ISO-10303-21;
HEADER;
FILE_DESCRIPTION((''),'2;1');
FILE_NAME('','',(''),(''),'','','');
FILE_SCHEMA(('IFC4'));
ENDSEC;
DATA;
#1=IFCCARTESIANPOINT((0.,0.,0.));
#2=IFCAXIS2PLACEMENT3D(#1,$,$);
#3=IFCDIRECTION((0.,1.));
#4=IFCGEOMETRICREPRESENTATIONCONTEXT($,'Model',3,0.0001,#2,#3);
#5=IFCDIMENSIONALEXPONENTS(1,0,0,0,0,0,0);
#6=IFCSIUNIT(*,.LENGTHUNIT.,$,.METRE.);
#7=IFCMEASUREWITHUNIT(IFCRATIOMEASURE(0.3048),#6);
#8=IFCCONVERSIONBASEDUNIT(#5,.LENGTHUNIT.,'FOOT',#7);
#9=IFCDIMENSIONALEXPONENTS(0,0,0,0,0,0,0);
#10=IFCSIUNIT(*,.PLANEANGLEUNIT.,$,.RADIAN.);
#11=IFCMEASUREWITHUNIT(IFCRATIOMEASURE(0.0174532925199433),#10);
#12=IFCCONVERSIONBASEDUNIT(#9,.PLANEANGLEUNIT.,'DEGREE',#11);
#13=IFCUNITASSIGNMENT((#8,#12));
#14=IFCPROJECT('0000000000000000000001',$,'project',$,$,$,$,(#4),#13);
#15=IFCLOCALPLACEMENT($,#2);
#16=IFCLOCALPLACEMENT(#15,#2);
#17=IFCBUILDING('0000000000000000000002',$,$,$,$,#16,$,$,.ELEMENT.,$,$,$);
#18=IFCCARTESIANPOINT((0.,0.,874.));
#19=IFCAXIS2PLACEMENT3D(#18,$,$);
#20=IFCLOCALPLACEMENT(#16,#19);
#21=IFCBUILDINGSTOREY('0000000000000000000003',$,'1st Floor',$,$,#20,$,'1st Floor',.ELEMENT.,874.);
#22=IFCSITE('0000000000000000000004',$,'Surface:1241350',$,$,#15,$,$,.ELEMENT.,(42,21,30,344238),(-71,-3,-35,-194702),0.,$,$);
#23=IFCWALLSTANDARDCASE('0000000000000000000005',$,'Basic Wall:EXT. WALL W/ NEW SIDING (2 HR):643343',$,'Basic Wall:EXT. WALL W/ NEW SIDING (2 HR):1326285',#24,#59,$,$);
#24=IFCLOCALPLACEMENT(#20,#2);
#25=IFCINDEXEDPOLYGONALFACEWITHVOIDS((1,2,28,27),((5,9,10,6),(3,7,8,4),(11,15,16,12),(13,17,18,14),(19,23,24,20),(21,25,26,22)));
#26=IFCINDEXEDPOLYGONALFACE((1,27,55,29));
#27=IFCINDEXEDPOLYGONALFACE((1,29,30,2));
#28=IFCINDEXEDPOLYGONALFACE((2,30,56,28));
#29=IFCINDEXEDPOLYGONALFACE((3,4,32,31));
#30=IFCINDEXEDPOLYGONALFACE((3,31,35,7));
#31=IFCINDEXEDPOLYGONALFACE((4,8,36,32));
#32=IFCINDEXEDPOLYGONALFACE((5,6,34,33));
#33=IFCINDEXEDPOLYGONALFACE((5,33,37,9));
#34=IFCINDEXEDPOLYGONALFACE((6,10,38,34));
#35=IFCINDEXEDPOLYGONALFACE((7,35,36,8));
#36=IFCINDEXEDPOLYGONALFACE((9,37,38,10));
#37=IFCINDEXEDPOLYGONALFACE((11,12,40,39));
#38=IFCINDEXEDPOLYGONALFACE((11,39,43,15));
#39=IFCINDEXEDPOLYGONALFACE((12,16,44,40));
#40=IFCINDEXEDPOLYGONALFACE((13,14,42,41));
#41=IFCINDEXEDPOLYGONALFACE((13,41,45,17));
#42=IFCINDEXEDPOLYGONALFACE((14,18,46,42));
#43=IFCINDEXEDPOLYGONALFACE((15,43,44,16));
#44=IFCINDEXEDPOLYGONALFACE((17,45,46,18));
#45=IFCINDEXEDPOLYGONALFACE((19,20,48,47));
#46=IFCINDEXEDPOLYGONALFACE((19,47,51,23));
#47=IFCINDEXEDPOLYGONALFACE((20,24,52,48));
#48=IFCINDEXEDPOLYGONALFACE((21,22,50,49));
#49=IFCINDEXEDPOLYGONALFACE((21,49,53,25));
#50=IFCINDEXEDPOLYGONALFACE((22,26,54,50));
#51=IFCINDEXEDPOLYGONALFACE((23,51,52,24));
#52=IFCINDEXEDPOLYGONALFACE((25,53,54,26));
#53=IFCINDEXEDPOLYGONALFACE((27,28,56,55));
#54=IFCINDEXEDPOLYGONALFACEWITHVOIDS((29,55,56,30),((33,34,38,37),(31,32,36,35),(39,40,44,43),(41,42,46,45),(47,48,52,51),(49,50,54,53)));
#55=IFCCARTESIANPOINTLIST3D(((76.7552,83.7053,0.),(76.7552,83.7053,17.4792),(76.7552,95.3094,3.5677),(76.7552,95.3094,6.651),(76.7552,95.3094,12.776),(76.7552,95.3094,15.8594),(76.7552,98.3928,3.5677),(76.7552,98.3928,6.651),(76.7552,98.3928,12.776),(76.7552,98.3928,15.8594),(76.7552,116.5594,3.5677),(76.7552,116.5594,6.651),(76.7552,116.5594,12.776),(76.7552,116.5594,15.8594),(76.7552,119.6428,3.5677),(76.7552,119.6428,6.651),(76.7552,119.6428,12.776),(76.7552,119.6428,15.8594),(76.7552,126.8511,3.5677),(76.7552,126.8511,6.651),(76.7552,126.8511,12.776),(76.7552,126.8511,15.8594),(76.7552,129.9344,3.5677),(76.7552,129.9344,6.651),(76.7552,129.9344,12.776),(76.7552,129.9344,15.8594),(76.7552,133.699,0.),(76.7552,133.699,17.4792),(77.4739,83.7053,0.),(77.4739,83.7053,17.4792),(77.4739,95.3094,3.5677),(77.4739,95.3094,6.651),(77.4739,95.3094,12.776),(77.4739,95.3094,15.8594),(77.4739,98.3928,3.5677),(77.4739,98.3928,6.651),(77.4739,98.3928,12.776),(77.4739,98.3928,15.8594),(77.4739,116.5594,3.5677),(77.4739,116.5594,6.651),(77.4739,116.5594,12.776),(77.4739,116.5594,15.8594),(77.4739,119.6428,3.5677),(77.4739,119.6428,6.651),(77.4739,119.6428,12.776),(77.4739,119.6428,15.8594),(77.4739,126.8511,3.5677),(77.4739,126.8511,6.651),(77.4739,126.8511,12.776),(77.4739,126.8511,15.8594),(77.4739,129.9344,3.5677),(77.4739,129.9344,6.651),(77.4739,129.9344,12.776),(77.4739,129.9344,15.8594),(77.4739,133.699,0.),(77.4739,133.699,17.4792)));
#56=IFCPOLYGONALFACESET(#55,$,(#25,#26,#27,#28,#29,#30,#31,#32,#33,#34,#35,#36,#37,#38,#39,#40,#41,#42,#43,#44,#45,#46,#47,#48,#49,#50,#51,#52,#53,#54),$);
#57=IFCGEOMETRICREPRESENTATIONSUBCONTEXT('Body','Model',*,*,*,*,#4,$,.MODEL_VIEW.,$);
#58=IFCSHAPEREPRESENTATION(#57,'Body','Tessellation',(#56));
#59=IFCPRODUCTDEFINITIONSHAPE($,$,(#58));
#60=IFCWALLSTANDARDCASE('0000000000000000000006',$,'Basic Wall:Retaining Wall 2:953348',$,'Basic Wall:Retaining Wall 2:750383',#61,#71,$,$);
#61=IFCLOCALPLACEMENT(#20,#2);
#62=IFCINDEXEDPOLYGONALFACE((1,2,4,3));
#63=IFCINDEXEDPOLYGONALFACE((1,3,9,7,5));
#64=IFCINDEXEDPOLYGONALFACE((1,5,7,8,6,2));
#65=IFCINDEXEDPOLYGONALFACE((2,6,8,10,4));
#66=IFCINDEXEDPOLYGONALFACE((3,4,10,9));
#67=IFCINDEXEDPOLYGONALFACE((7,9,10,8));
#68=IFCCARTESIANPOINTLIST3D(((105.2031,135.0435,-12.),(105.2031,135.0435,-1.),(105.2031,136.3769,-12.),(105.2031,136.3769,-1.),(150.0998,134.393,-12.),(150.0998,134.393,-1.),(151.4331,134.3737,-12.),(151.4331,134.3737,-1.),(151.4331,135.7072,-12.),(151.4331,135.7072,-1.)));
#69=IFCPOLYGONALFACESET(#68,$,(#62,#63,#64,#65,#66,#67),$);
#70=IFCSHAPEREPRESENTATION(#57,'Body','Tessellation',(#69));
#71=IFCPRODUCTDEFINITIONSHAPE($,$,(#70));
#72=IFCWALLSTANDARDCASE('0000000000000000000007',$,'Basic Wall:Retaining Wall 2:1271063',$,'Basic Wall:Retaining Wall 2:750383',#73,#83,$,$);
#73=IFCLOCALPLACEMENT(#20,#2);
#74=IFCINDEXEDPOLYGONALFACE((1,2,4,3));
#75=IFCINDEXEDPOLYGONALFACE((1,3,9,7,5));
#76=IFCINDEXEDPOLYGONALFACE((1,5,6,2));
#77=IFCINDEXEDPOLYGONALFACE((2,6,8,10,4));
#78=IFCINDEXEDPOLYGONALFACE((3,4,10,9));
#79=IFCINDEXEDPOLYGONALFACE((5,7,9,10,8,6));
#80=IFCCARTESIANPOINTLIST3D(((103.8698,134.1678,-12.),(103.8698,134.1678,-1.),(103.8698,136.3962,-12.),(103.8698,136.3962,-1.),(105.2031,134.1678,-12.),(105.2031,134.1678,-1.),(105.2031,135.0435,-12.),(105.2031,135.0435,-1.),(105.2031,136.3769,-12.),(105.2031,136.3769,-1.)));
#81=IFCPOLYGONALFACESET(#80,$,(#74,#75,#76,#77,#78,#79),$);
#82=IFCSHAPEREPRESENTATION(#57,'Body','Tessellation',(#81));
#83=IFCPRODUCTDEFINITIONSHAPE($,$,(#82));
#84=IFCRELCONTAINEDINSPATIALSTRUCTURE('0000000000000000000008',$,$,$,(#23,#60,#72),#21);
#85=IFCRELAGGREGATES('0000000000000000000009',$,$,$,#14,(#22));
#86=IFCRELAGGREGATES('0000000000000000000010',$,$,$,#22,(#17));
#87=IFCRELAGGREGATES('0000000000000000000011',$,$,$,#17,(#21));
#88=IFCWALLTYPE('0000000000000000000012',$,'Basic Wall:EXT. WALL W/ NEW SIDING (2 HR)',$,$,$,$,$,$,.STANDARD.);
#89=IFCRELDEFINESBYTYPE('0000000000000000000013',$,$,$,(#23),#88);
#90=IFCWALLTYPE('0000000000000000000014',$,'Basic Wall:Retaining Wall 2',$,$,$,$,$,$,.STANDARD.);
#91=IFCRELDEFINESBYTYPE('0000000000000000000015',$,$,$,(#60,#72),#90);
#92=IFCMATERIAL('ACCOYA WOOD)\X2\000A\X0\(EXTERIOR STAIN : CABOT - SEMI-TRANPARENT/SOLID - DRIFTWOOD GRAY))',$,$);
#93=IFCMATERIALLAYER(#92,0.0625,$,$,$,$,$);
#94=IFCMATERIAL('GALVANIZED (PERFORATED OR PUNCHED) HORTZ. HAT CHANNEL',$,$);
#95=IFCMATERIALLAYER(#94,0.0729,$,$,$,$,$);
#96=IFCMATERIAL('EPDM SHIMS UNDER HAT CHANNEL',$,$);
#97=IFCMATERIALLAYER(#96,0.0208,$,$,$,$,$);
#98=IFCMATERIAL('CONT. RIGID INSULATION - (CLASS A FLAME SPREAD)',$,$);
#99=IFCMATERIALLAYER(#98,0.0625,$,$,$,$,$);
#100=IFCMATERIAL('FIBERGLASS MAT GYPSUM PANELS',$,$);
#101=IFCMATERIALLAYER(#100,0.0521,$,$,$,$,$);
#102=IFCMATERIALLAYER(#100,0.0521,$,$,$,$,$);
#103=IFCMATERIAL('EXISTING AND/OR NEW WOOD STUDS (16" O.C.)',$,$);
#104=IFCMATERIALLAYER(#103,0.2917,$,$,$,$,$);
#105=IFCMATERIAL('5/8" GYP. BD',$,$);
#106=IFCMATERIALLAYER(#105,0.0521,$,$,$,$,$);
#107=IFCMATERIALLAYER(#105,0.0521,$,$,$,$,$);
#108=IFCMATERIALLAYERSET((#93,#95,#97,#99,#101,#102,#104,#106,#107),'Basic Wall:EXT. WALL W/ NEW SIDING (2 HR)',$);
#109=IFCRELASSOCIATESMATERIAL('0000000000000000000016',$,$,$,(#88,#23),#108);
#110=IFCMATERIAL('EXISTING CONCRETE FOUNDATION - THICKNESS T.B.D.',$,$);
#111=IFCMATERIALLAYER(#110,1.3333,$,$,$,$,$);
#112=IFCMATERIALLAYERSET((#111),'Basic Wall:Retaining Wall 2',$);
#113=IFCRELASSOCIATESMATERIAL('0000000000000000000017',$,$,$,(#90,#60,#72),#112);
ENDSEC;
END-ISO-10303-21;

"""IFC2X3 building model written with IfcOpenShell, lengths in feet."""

from ifc_helpers import new_model, entity, si_unit, converted_unit, direction, frame, frame_2d, origin, place, context, subcontext, project, spatial, polyline, rectangle, outline, extrude, material, layer, layer_set, layer_usage, type_object, element, save


model = new_model("IFC2X3")

# Units and contexts
model_context = context("Model", 3, precision=0.0001, world=origin(), true_north=direction((0.0, 1.0)))
body_context = subcontext(model_context, "Body", "Model", "MODEL_VIEW")
ifc_project = project(units=[converted_unit("LENGTHUNIT", "FOOT", entity("IfcRatioMeasure", 0.3048), si_unit("LENGTHUNIT", "METRE"), dimensions=[1, 0, 0, 0, 0, 0, 0]), converted_unit("PLANEANGLEUNIT", "DEGREE", entity("IfcRatioMeasure", 0.0174532925199433), si_unit("PLANEANGLEUNIT", "RADIAN"), dimensions=[0, 0, 0, 0, 0, 0, 0])], contexts=[model_context])

# Site, building, storey
site_placement = place(None, origin())
site = spatial("IfcSite", under=ifc_project, at=site_placement, Name="Surface:1241350", CompositionType="ELEMENT", RefLatitude=(42, 21, 30, 344238), RefLongitude=(-71, -3, -35, -194702), RefElevation=0.0)
building_placement = place(site_placement, origin())
building = spatial("IfcBuilding", under=site, at=building_placement, CompositionType="ELEMENT")
storey_placement = place(building_placement, frame((0.0, 0.0, 874.0)))
storey = spatial("IfcBuildingStorey", under=building, at=storey_placement, Name="1st Floor", LongName="1st Floor", CompositionType="ELEMENT", Elevation=874.0)

# Wall, openings
ifc_material_1 = material(Name="ACCOYA WOOD)\n(EXTERIOR STAIN : CABOT - SEMI-TRANPARENT/SOLID - DRIFTWOOD GRAY))")
ifc_layer_1 = layer(ifc_material_1, 0.0625)
ifc_material_2 = material(Name="GALVANIZED (PERFORATED OR PUNCHED) HORTZ. HAT CHANNEL")
ifc_layer_2 = layer(ifc_material_2, 0.0729)
ifc_material_3 = material(Name="EPDM SHIMS UNDER HAT CHANNEL")
ifc_layer_3 = layer(ifc_material_3, 0.0208)
ifc_material_4 = material(Name="CONT. RIGID INSULATION - (CLASS A FLAME SPREAD)")
ifc_layer_4 = layer(ifc_material_4, 0.0625)
ifc_material_5 = material(Name="FIBERGLASS MAT GYPSUM PANELS")
ifc_layer_5 = layer(ifc_material_5, 0.0521)
ifc_layer_6 = layer(ifc_material_5, 0.0521)
ifc_material_6 = material(Name="EXISTING AND/OR NEW WOOD STUDS (16\" O.C.)")
ifc_layer_7 = layer(ifc_material_6, 0.2917)
ifc_material_7 = material(Name="5/8\" GYP. BD")
ifc_layer_8 = layer(ifc_material_7, 0.0521)
ifc_layer_9 = layer(ifc_material_7, 0.0521)
ifc_layer_set_1 = layer_set([ifc_layer_1, ifc_layer_2, ifc_layer_3, ifc_layer_4, ifc_layer_5, ifc_layer_6, ifc_layer_7, ifc_layer_8, ifc_layer_9], Name="Basic Wall:EXT. WALL W/ NEW SIDING (2 HR)")
ifc_layer_usage_1 = layer_usage(ifc_layer_set_1, "AXIS2", "NEGATIVE", 0.3594)
wall_type_1 = type_object("IfcWallType", Name="Basic Wall:EXT. WALL W/ NEW SIDING (2 HR)", PredefinedType="STANDARD", material=ifc_layer_set_1)
wall_1_placement = place(storey_placement, frame((77.1146, 83.7053, 0.0), z_axis=(0.0, 0.0, 1.0), x_axis=(0.0, 1.0, 0.0)))
wall_1 = element("IfcWallStandardCase", 1, at=wall_1_placement, inside=storey, type_object=wall_type_1, material=ifc_layer_usage_1, Name="Basic Wall:EXT. WALL W/ NEW SIDING (2 HR):643343", ObjectType="Basic Wall:EXT. WALL W/ NEW SIDING (2 HR):1326285", context=body_context, shape_type="SweptSolid", body=[
    extrude(rectangle(XDim=49.9937, YDim=0.7188, at=frame_2d((24.9969, 0.0), x_axis=(-1.0, 0.0))), origin(), (0.0, 0.0, 1.0), 17.4792),
])
opening_1_placement = place(wall_1_placement, frame((-83.7053, 77.1146, 9.2083), z_axis=(0.0, 0.0, 1.0), x_axis=(0.0, -1.0, 0.0)))
element("IfcOpeningElement", 2, at=opening_1_placement, cuts=wall_1, ObjectType="Opening", context=body_context, shape_type="SweptSolid", body=[
    extrude(rectangle(XDim=3.0833, YDim=3.0833, at=frame_2d((0.0, 0.0), x_axis=(0.0, 1.0))), frame((77.4739, 96.8511, 5.1094), z_axis=(-1.0, 0.0, 0.0), x_axis=(0.0, 1.0, 0.0)), (0.0, 0.0, 1.0), 1.7188),
])
opening_2_placement = place(wall_1_placement, frame((-83.7053, 77.1146, 9.2083), z_axis=(0.0, 0.0, 1.0), x_axis=(0.0, -1.0, 0.0)))
element("IfcOpeningElement", 3, at=opening_2_placement, cuts=wall_1, ObjectType="Opening", context=body_context, shape_type="SweptSolid", body=[
    extrude(rectangle(XDim=3.0833, YDim=3.0833, at=frame_2d((0.0, 0.0), x_axis=(0.0, 1.0))), frame((77.4739, 128.3928, 5.1094), z_axis=(-1.0, 0.0, 0.0), x_axis=(0.0, 1.0, 0.0)), (0.0, 0.0, 1.0), 1.7188),
])
opening_3_placement = place(wall_1_placement, frame((-83.7053, 77.1146, 9.2083), z_axis=(0.0, 0.0, 1.0), x_axis=(0.0, -1.0, 0.0)))
element("IfcOpeningElement", 4, at=opening_3_placement, cuts=wall_1, ObjectType="Opening", context=body_context, shape_type="SweptSolid", body=[
    extrude(rectangle(XDim=3.0833, YDim=3.0833, at=frame_2d((0.0, 0.0), x_axis=(0.0, 1.0))), frame((77.4739, 118.1011, 5.1094), z_axis=(-1.0, 0.0, 0.0), x_axis=(0.0, 1.0, 0.0)), (0.0, 0.0, 1.0), 1.7188),
])
opening_4_placement = place(wall_1_placement, frame((-83.7053, 77.1146, 0.0), z_axis=(0.0, 0.0, 1.0), x_axis=(0.0, -1.0, 0.0)))
element("IfcOpeningElement", 5, at=opening_4_placement, cuts=wall_1, ObjectType="Opening", context=body_context, shape_type="SweptSolid", body=[
    extrude(rectangle(XDim=3.0833, YDim=3.0833, at=frame_2d((0.0, 0.0), x_axis=(0.0, 1.0))), frame((77.4739, 118.1011, 5.1094), z_axis=(-1.0, 0.0, 0.0), x_axis=(0.0, 1.0, 0.0)), (0.0, 0.0, 1.0), 1.7188),
])
opening_5_placement = place(wall_1_placement, frame((-83.7053, 77.1146, 0.0), z_axis=(0.0, 0.0, 1.0), x_axis=(0.0, -1.0, 0.0)))
element("IfcOpeningElement", 6, at=opening_5_placement, cuts=wall_1, ObjectType="Opening", context=body_context, shape_type="SweptSolid", body=[
    extrude(rectangle(XDim=3.0833, YDim=3.0833, at=frame_2d((0.0, 0.0), x_axis=(0.0, 1.0))), frame((77.4739, 96.8511, 5.1094), z_axis=(-1.0, 0.0, 0.0), x_axis=(0.0, 1.0, 0.0)), (0.0, 0.0, 1.0), 1.7188),
])
opening_6_placement = place(wall_1_placement, frame((-83.7053, 77.1146, 0.0), z_axis=(0.0, 0.0, 1.0), x_axis=(0.0, -1.0, 0.0)))
element("IfcOpeningElement", 7, at=opening_6_placement, cuts=wall_1, ObjectType="Opening", context=body_context, shape_type="SweptSolid", body=[
    extrude(rectangle(XDim=3.0833, YDim=3.0833, at=frame_2d((0.0, 0.0), x_axis=(0.0, 1.0))), frame((77.4739, 128.3928, 5.1094), z_axis=(-1.0, 0.0, 0.0), x_axis=(0.0, 1.0, 0.0)), (0.0, 0.0, 1.0), 1.7188),
])

# Walls
ifc_material_8 = material(Name="EXISTING CONCRETE FOUNDATION - THICKNESS T.B.D.")
ifc_layer_10 = layer(ifc_material_8, 1.3333)
ifc_layer_set_2 = layer_set([ifc_layer_10], Name="Basic Wall:Retaining Wall 2")
ifc_layer_usage_2 = layer_usage(ifc_layer_set_2, "AXIS2", "NEGATIVE", 0.6667)
wall_type_2 = type_object("IfcWallType", Name="Basic Wall:Retaining Wall 2", PredefinedType="STANDARD", material=ifc_layer_set_2)
wall_2_placement = place(storey_placement, frame((105.1935, 135.7103, -12.0), z_axis=(0.0, 0.0, 1.0), x_axis=(0.999895, -0.014486, 0.0)))
element("IfcWallStandardCase", 8, at=wall_2_placement, inside=storey, type_object=wall_type_2, material=ifc_layer_usage_2, Name="Basic Wall:Retaining Wall 2:953348", ObjectType="Basic Wall:Retaining Wall 2:750383", context=body_context, shape_type="SweptSolid", body=[
    extrude(outline(polyline([(46.2542, -0.6667), (46.2349, 0.6667), (0.0, 0.6667), (0.0193, -0.6667), (44.9207, -0.6667), (46.2542, -0.6667)])), origin(), (0.0, 0.0, 1.0), 11.0),
])
ifc_layer_usage_3 = layer_usage(ifc_layer_set_2, "AXIS2", "NEGATIVE", 0.6667)
wall_3_placement = place(storey_placement, frame((104.5364, 136.3962, -12.0), z_axis=(0.0, 0.0, 1.0), x_axis=(0.0, -1.0, 0.0)))
element("IfcWallStandardCase", 9, at=wall_3_placement, inside=storey, type_object=wall_type_2, material=ifc_layer_usage_3, Name="Basic Wall:Retaining Wall 2:1271063", ObjectType="Basic Wall:Retaining Wall 2:750383", context=body_context, shape_type="SweptSolid", body=[
    extrude(outline(polyline([(2.2285, -0.6667), (2.2285, 0.6667), (1.3528, 0.6667), (0.0193, 0.6667), (0.0, -0.6667), (2.2285, -0.6667)])), origin(), (0.0, 0.0, 1.0), 11.0),
])

save(model, "model.ifc")
